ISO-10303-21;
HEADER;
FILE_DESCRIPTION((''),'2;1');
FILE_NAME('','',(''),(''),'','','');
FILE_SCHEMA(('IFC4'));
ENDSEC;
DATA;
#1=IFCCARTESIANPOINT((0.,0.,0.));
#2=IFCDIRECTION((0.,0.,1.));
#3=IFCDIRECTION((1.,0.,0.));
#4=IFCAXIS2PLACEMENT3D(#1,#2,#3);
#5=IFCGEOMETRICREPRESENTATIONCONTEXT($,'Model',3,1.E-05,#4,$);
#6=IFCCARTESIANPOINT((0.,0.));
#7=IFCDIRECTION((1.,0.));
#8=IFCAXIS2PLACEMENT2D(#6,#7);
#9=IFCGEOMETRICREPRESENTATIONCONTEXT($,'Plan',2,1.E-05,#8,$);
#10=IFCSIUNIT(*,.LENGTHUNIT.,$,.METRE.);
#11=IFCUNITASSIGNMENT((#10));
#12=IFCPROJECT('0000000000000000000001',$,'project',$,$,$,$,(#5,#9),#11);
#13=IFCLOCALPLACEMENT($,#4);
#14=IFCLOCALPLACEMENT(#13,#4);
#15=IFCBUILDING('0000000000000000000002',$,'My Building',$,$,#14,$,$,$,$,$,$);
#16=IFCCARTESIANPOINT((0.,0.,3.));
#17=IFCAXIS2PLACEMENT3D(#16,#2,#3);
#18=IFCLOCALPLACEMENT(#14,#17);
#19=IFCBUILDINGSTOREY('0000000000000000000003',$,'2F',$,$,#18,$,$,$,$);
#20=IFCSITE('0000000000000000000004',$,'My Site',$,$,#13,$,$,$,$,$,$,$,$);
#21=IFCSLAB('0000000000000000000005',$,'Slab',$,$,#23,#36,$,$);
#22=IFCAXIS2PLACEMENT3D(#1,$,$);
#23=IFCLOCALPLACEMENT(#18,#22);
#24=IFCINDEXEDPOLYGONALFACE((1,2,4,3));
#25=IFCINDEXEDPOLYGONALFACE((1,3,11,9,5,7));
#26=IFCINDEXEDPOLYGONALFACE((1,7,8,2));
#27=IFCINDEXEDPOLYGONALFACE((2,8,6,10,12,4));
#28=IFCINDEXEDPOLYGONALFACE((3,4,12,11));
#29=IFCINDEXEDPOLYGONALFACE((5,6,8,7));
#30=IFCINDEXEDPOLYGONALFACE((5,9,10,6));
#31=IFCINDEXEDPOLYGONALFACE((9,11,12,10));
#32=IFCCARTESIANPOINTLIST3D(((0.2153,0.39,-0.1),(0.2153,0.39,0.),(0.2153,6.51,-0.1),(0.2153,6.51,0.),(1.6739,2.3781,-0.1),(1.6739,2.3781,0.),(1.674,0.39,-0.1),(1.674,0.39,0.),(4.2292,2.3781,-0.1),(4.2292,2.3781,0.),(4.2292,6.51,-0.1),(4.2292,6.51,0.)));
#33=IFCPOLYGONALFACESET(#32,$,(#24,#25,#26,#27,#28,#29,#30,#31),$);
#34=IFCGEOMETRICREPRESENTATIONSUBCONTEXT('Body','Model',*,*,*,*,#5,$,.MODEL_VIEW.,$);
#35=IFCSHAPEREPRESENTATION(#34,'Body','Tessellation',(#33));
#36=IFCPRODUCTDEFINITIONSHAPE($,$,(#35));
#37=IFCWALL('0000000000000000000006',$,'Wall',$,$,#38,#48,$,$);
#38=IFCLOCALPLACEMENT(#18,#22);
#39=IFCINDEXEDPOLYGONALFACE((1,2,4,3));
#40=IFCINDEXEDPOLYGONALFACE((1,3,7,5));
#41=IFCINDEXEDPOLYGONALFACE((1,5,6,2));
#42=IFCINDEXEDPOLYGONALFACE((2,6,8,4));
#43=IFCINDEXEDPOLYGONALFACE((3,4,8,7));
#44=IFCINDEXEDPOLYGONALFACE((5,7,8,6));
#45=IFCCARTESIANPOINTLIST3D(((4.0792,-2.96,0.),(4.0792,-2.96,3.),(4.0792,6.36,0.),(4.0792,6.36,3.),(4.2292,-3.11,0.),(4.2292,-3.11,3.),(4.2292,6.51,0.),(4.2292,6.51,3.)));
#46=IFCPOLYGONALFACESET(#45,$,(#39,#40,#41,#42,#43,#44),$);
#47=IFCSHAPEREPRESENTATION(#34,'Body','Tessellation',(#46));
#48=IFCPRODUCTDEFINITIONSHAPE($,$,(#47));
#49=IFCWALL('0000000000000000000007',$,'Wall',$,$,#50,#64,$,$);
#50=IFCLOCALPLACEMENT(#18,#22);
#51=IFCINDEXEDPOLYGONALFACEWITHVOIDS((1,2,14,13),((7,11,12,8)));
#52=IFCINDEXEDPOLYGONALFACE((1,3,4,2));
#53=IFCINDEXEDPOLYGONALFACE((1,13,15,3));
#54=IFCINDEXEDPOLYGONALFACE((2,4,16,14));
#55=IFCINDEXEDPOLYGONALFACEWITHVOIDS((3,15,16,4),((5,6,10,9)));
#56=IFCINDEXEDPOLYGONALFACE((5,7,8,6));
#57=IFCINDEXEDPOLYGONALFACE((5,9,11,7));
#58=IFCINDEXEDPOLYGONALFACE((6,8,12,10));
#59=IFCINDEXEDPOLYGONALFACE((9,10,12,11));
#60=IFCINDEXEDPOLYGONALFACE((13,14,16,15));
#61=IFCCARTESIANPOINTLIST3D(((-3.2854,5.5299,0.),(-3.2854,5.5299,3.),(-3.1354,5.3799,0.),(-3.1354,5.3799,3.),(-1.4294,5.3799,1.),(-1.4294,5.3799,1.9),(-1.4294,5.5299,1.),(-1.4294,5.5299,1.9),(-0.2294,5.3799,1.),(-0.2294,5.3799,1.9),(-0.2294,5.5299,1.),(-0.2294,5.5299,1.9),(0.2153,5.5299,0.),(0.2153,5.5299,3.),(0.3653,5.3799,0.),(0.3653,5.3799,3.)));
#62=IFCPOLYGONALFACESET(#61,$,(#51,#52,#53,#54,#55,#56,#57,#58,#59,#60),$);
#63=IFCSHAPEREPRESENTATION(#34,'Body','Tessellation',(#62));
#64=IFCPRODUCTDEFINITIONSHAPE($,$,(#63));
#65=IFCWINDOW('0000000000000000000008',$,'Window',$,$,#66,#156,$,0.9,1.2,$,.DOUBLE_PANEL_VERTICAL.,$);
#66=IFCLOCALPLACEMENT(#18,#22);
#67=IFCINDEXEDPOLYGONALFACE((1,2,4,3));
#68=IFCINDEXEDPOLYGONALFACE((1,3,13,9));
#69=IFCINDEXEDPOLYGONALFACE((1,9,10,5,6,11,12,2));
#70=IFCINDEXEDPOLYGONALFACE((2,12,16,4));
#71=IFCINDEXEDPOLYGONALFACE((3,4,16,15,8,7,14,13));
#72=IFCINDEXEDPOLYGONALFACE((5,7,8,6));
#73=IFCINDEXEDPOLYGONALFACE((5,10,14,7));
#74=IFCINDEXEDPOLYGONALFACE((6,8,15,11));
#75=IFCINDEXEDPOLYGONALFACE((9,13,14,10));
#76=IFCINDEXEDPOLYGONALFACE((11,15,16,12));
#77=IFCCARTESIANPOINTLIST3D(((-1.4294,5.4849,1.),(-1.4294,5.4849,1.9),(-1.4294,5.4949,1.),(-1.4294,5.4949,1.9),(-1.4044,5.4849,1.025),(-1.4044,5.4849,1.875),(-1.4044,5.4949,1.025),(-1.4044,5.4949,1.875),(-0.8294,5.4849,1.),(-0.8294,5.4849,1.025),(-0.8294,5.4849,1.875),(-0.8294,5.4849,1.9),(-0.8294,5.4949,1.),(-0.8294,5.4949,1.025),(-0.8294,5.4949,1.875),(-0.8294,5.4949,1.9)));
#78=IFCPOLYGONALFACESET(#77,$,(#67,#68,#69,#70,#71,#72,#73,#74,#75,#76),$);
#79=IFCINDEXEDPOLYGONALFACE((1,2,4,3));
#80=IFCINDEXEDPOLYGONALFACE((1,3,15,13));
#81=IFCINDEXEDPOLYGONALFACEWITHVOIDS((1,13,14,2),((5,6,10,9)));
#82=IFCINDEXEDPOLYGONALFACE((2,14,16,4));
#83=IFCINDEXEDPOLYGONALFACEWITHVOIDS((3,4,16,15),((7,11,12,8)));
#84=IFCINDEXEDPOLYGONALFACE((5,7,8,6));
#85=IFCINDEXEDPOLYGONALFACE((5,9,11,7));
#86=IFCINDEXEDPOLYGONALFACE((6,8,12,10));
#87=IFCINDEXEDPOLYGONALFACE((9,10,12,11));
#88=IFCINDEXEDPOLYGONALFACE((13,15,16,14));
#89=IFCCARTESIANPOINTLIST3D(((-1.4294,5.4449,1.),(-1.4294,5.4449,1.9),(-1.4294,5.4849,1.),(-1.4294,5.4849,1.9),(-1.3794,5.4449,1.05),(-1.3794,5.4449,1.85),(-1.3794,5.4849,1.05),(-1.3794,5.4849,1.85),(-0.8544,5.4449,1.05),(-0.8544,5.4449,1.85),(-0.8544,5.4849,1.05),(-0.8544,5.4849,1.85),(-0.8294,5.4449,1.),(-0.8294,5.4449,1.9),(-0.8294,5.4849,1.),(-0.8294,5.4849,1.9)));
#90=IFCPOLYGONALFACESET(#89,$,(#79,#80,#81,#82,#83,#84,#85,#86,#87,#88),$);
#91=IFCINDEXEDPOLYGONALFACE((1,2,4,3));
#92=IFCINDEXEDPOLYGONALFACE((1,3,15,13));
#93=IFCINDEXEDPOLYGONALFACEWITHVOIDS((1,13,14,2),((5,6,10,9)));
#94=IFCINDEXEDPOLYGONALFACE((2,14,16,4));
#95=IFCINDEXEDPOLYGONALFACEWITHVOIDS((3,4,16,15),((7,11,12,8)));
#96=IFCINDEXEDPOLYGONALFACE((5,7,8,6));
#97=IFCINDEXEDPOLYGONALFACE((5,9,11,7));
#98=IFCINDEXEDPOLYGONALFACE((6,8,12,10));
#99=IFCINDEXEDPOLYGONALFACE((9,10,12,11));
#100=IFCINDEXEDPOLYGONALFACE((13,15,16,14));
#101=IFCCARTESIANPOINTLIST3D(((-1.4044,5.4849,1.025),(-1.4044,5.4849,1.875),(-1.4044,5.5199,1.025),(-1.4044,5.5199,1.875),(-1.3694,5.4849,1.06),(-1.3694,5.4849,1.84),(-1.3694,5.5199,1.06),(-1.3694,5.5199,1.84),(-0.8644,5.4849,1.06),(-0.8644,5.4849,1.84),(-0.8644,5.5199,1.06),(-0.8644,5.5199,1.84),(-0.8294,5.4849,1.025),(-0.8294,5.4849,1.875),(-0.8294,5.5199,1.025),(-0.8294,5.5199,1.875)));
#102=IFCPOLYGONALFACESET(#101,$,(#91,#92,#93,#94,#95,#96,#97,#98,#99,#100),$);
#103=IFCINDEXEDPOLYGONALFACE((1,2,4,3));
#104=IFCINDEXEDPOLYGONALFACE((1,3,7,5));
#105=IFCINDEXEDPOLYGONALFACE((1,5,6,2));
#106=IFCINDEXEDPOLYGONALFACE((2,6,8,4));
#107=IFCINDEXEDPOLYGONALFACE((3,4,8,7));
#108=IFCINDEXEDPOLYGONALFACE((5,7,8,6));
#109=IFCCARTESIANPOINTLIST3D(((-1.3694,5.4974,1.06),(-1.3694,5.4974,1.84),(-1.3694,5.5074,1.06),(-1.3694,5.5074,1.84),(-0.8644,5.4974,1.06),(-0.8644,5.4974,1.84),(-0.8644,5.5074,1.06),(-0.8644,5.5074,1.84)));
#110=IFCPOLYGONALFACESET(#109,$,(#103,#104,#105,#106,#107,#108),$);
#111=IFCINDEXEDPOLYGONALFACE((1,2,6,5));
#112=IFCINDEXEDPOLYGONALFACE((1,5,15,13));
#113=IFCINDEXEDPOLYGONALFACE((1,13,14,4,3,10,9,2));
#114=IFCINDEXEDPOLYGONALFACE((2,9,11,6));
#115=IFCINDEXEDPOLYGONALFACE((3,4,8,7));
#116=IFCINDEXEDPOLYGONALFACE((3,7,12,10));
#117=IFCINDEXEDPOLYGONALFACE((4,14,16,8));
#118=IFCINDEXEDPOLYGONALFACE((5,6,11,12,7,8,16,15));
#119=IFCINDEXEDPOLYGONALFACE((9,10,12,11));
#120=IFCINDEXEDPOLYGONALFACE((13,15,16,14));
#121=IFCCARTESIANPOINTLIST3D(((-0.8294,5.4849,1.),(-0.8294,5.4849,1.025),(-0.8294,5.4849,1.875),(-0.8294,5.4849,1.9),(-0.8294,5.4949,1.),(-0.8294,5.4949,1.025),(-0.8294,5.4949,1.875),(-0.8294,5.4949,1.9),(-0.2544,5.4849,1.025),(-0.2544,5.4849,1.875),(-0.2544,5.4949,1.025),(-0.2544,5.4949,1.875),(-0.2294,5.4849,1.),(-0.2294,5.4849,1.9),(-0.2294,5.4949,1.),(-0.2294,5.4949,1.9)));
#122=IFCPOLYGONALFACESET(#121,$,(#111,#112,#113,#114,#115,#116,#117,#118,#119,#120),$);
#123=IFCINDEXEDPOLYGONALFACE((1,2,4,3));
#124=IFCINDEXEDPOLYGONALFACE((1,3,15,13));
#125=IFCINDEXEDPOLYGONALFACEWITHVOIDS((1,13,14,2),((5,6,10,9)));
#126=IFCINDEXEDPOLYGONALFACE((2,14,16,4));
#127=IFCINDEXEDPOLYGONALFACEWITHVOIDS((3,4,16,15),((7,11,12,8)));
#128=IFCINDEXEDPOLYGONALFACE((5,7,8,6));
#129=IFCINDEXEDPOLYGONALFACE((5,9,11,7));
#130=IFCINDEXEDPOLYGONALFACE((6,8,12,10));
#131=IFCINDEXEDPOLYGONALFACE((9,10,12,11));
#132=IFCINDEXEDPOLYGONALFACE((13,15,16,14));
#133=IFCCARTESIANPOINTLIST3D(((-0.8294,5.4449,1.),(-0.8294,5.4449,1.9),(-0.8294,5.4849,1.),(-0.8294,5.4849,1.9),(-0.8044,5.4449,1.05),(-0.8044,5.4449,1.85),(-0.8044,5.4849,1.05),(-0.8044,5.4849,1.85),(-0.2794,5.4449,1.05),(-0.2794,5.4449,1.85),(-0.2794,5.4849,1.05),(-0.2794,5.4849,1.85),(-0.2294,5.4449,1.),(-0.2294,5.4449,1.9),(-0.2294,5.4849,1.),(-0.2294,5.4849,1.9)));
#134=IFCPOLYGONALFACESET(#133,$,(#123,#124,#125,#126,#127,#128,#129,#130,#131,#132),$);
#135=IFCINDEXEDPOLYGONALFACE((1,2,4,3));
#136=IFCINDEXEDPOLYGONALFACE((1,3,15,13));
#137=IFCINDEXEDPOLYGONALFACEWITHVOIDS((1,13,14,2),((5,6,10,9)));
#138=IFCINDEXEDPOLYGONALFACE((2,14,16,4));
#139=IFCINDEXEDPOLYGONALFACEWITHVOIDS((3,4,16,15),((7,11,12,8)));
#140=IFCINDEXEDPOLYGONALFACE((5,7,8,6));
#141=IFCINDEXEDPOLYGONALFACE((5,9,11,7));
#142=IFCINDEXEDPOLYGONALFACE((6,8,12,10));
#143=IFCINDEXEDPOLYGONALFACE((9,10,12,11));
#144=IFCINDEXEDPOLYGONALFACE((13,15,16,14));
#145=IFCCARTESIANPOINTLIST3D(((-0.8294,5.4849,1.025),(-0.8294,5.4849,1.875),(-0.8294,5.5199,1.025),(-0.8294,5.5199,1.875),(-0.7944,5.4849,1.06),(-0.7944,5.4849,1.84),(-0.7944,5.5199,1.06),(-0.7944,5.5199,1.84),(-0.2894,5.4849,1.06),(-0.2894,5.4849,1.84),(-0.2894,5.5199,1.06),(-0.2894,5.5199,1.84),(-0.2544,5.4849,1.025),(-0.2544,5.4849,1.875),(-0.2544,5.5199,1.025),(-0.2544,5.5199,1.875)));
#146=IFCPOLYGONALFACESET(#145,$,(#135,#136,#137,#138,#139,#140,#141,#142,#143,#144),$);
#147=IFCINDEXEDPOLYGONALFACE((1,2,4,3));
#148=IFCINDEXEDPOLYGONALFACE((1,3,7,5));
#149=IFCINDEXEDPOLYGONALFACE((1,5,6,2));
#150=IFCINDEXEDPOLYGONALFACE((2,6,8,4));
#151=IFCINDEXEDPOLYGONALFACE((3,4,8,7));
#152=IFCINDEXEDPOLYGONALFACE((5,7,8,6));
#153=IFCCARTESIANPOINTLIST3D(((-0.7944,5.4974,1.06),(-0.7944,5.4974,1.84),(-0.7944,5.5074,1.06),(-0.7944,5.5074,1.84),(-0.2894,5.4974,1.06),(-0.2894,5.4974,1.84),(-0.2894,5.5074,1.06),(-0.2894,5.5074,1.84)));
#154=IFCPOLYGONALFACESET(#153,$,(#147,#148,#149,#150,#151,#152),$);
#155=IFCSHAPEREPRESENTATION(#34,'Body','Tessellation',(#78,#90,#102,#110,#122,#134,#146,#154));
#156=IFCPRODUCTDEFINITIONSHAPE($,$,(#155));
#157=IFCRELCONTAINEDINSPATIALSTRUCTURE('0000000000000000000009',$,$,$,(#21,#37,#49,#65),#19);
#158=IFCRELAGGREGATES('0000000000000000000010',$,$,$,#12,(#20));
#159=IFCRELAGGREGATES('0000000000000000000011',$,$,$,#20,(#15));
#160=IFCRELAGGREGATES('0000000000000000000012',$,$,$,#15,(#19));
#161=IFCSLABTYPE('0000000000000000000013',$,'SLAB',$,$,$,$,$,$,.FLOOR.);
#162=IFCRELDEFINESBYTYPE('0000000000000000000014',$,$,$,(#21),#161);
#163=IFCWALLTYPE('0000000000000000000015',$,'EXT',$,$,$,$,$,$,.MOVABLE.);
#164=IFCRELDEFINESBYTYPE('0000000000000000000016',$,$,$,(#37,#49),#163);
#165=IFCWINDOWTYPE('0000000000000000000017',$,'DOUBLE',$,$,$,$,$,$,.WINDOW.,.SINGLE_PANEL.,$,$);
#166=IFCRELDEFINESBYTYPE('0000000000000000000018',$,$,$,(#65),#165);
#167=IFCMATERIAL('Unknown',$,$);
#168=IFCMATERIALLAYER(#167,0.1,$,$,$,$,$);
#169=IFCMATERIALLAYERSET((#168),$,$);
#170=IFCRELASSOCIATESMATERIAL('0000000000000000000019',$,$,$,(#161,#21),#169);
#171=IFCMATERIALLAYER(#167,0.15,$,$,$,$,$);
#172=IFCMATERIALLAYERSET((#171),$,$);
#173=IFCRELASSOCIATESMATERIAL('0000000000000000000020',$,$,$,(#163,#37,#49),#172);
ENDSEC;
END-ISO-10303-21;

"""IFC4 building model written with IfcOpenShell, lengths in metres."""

from ifc_helpers import new_model, entity, si_unit, frame, origin_with_axes, origin_2d_with_axis, place, context, subcontext, project, spatial, line, indexed_curve, outline, extrude, shape, source, transform, mapped, material, layer, layer_set, layer_usage, type_object, type_shapes, element, fill, save


model = new_model("IFC4")

# Units and contexts
model_context = context("Model", 3, precision=1e-05, world=origin_with_axes())
plan_context = context("Plan", 2, precision=1e-05, world=origin_2d_with_axis())
body_context_1 = subcontext(model_context, "Body", "Model", "MODEL_VIEW")
body_context_2 = subcontext(plan_context, "Body", "Plan", "PLAN_VIEW")
ifc_project = project(units=[si_unit("LENGTHUNIT", "METRE")], contexts=[model_context, plan_context])

# Site, building, storey
site_placement = place(None, origin_with_axes())
site = spatial("IfcSite", under=ifc_project, at=site_placement, Name="My Site")
building_placement = place(site_placement, origin_with_axes())
building = spatial("IfcBuilding", under=site, at=building_placement, Name="My Building")
storey_placement = place(building_placement, frame((0.0, 0.0, 3.0), z_axis=(0.0, 0.0, 1.0), x_axis=(1.0, 0.0, 0.0)))
storey = spatial("IfcBuildingStorey", under=building, at=storey_placement, Name="2F")

# Slab
ifc_material = material(Name="Unknown")
ifc_layer_1 = layer(ifc_material, 0.1)
ifc_layer_set_1 = layer_set([ifc_layer_1])
ifc_layer_usage_1 = layer_usage(ifc_layer_set_1, "AXIS3", "POSITIVE", -0.1)
slab_type = type_object("IfcSlabType", Name="SLAB", PredefinedType="FLOOR", material=ifc_layer_set_1)
slab_placement = place(storey_placement, frame((1.6739, 2.3781, 0.0), z_axis=(0.0, 0.0, 1.0), x_axis=(1.0, 0.0, 0.0)))
element("IfcSlab", 1, at=slab_placement, inside=storey, type_object=slab_type, material=ifc_layer_usage_1, Name="Slab", context=body_context_1, shape_type="SweptSolid", body=[
    extrude(outline(indexed_curve([(0.0, 0.0), (2.5552, 0.0), (2.5552, 4.1319), (-1.4586, 4.1319), (-1.4586, -1.9882), (0.0, -1.9882), (0.0, 0.0)])), frame((0.0, 0.0, -0.1), z_axis=(0.0, 0.0, 1.0), x_axis=(1.0, 0.0, 0.0)), (0.0, 0.0, 1.0), 0.1),
])

# Wall
ifc_layer_2 = layer(ifc_material, 0.15)
ifc_layer_set_2 = layer_set([ifc_layer_2])
ifc_layer_usage_2 = layer_usage(ifc_layer_set_2, "AXIS2", "POSITIVE", -0.15)
wall_type_1 = type_object("IfcWallType", Name="EXT", PredefinedType="MOVABLE", material=ifc_layer_set_2)
wall_1_placement = place(storey_placement, frame((4.2292, 6.51, 0.0), z_axis=(0.0, 0.0, 1.0), x_axis=(0.0, -1.0, 0.0)))
element("IfcWall", 2, at=wall_1_placement, inside=storey, type_object=wall_type_1, material=ifc_layer_usage_2, Name="Wall", context=body_context_1, shape_type="SweptSolid", body=[
    extrude(outline(indexed_curve([(0.15, -0.15), (0.0, 0.0), (9.62, 0.0), (9.47, -0.15)], segments=[line(1, 2, 3, 4, 1)])), origin_with_axes(), (0.0, 0.0, 1.0), 3.0),
])

# Wall, opening, window
ifc_layer_usage_3 = layer_usage(ifc_layer_set_2, "AXIS2", "POSITIVE", -0.15)
wall_2_placement = place(storey_placement, frame((-3.2854, 5.5299, 0.0), z_axis=(0.0, 0.0, 1.0), x_axis=(1.0, 0.0, 0.0)))
wall_2 = element("IfcWall", 3, at=wall_2_placement, inside=storey, type_object=wall_type_1, material=ifc_layer_usage_3, Name="Wall", context=body_context_1, shape_type="SweptSolid", body=[
    extrude(outline(indexed_curve([(0.15, -0.15), (0.0, 0.0), (3.5007, 0.0), (3.6507, -0.15)], segments=[line(1, 2, 3, 4, 1)])), origin_with_axes(), (0.0, 0.0, 1.0), 3.0),
])
placement_1 = place(storey_placement, frame((-1.4294, 5.3949, 1.0), z_axis=(0.0, 0.0, 1.0), x_axis=(1.0, 0.0, 0.0)))
opening_1 = element("IfcOpeningElement", 4, at=placement_1, cuts=wall_2, PredefinedType="OPENING", context=body_context_1, shape_type="SweptSolid", body=[
    extrude(outline(indexed_curve([(0.0, 0.0), (1.2, 0.0), (1.2, 0.9), (0.0, 0.9)], segments=[line(1, 2, 3, 4, 1)])), frame((0.0, -0.6, 0.0), z_axis=(0.0, -1.0, 0.0), x_axis=(1.0, 0.0, 0.0)), (0.0, 0.0, -1.0), 1.2),
])
window_type_1 = type_object("IfcWindowType", Name="DOUBLE", PartitioningType="SINGLE_PANEL", PredefinedType="WINDOW")
shared_shape_1 = source(origin_with_axes(), body_context_1, "Body", "SweptSolid", [
    extrude(outline(indexed_curve([(0.6, 0.0), (0.0, 0.0), (0.0, 0.9), (0.6, 0.9), (0.6, 0.875), (0.025, 0.875), (0.025, 0.025), (0.6, 0.025)], segments=[line(1, 2, 3, 4, 5, 6, 7, 8, 1)])), frame((0.0, 0.09, 0.0), z_axis=(0.0, -1.0, 0.0), x_axis=(1.0, 0.0, 0.0)), (0.0, 0.0, -1.0), 0.01),
    extrude(outline(indexed_curve([(0.0, 0.0), (0.6, 0.0), (0.6, 0.9), (0.0, 0.9)], segments=[line(1, 2, 3, 4, 1)]), holes=[indexed_curve([(0.05, 0.05), (0.575, 0.05), (0.575, 0.85), (0.05, 0.85)], segments=[line(1, 2, 3, 4, 1)])]), frame((0.0, 0.05, 0.0), z_axis=(0.0, -1.0, 0.0), x_axis=(1.0, 0.0, 0.0)), (0.0, 0.0, -1.0), 0.04),
    extrude(outline(indexed_curve([(0.0, 0.0), (0.575, 0.0), (0.575, 0.85), (0.0, 0.85)], segments=[line(1, 2, 3, 4, 1)]), holes=[indexed_curve([(0.035, 0.035), (0.54, 0.035), (0.54, 0.815), (0.035, 0.815)], segments=[line(1, 2, 3, 4, 1)])]), frame((0.025, 0.09, 0.025), z_axis=(0.0, -1.0, 0.0), x_axis=(1.0, 0.0, 0.0)), (0.0, 0.0, -1.0), 0.035),
    extrude(outline(indexed_curve([(0.035, 0.035), (0.54, 0.035), (0.54, 0.815), (0.035, 0.815)], segments=[line(1, 2, 3, 4, 1)])), frame((0.025, 0.1025, 0.025), z_axis=(0.0, -1.0, 0.0), x_axis=(1.0, 0.0, 0.0)), (0.0, 0.0, -1.0), 0.01),
    extrude(outline(indexed_curve([(0.0, 0.9), (0.6, 0.9), (0.6, 0.0), (0.0, 0.0), (0.0, 0.025), (0.575, 0.025), (0.575, 0.875), (0.0, 0.875)], segments=[line(1, 2, 3, 4, 5, 6, 7, 8, 1)])), frame((0.6, 0.09, 0.0), z_axis=(0.0, -1.0, 0.0), x_axis=(1.0, 0.0, 0.0)), (0.0, 0.0, -1.0), 0.01),
    extrude(outline(indexed_curve([(0.0, 0.0), (0.6, 0.0), (0.6, 0.9), (0.0, 0.9)], segments=[line(1, 2, 3, 4, 1)]), holes=[indexed_curve([(0.025, 0.05), (0.55, 0.05), (0.55, 0.85), (0.025, 0.85)], segments=[line(1, 2, 3, 4, 1)])]), frame((0.6, 0.05, 0.0), z_axis=(0.0, -1.0, 0.0), x_axis=(1.0, 0.0, 0.0)), (0.0, 0.0, -1.0), 0.04),
    extrude(outline(indexed_curve([(0.0, 0.0), (0.575, 0.0), (0.575, 0.85), (0.0, 0.85)], segments=[line(1, 2, 3, 4, 1)]), holes=[indexed_curve([(0.035, 0.035), (0.54, 0.035), (0.54, 0.815), (0.035, 0.815)], segments=[line(1, 2, 3, 4, 1)])]), frame((0.6, 0.09, 0.025), z_axis=(0.0, -1.0, 0.0), x_axis=(1.0, 0.0, 0.0)), (0.0, 0.0, -1.0), 0.035),
    extrude(outline(indexed_curve([(0.035, 0.815), (0.54, 0.815), (0.54, 0.035), (0.035, 0.035), (0.035, 0.815)])), frame((0.6, 0.1025, 0.025), z_axis=(0.0, -1.0, 0.0), x_axis=(1.0, 0.0, 0.0)), (0.0, 0.0, -1.0), 0.01),
])
shared_shape_2 = source(origin_with_axes(), body_context_2, "Body", "Curve2D", [
    entity("IfcIndexedPolyCurve", entity("IfcCartesianPointList2D", [[0.05, 0.05], [0.575, 0.05]])),
    entity("IfcIndexedPolyCurve", entity("IfcCartesianPointList2D", [[0.0, 0.1], [0.025, 0.1], [0.025, 0.09], [0.05, 0.09], [0.05, 0.05], [0.0, 0.05]]), [entity("IfcLineIndex", [1, 2, 3, 4, 5, 6, 1])]),
    entity("IfcIndexedPolyCurve", entity("IfcCartesianPointList2D", [[0.6, 0.1], [0.6, 0.1], [0.6, 0.09], [0.575, 0.09], [0.575, 0.05], [0.6, 0.05]])),
    entity("IfcIndexedPolyCurve", entity("IfcCartesianPointList2D", [[0.025, 0.09], [0.06, 0.09], [0.06, 0.125], [0.025, 0.125]]), [entity("IfcLineIndex", [1, 2, 3, 4, 1])]),
    entity("IfcIndexedPolyCurve", entity("IfcCartesianPointList2D", [[0.6, 0.09], [0.565, 0.09], [0.565, 0.125], [0.6, 0.125]]), [entity("IfcLineIndex", [1, 2, 3, 4, 1])]),
    entity("IfcIndexedPolyCurve", entity("IfcCartesianPointList2D", [[0.06, 0.09], [0.565, 0.09]])),
    entity("IfcIndexedPolyCurve", entity("IfcCartesianPointList2D", [[0.06, 0.125], [0.565, 0.125]])),
    entity("IfcIndexedPolyCurve", entity("IfcCartesianPointList2D", [[0.06, 0.1075], [0.565, 0.1075]])),
    entity("IfcIndexedPolyCurve", entity("IfcCartesianPointList2D", [[0.625, 0.05], [1.15, 0.05]])),
    entity("IfcIndexedPolyCurve", entity("IfcCartesianPointList2D", [[0.6, 0.1], [0.6, 0.1], [0.6, 0.09], [0.625, 0.09], [0.625, 0.05], [0.6, 0.05]])),
    entity("IfcIndexedPolyCurve", entity("IfcCartesianPointList2D", [[1.2, 0.1], [1.175, 0.1], [1.175, 0.09], [1.15, 0.09], [1.15, 0.05], [1.2, 0.05]]), [entity("IfcLineIndex", [1, 2, 3, 4, 5, 6, 1])]),
    entity("IfcIndexedPolyCurve", entity("IfcCartesianPointList2D", [[0.6, 0.09], [0.635, 0.09], [0.635, 0.125], [0.6, 0.125]]), [entity("IfcLineIndex", [1, 2, 3, 4, 1])]),
    entity("IfcIndexedPolyCurve", entity("IfcCartesianPointList2D", [[1.175, 0.09], [1.14, 0.09], [1.14, 0.125], [1.175, 0.125]]), [entity("IfcLineIndex", [1, 2, 3, 4, 1])]),
    entity("IfcIndexedPolyCurve", entity("IfcCartesianPointList2D", [[0.635, 0.09], [1.14, 0.09]])),
    entity("IfcIndexedPolyCurve", entity("IfcCartesianPointList2D", [[0.635, 0.125], [1.14, 0.125]])),
    entity("IfcIndexedPolyCurve", entity("IfcCartesianPointList2D", [[0.635, 0.1075], [1.14, 0.1075]])),
])
type_shapes(window_type_1, [shared_shape_1, shared_shape_2])
window_1 = element("IfcWindow", 5, at=placement_1, inside=storey, type_object=window_type_1, Name="Window", OverallHeight=0.9, OverallWidth=1.2, PartitioningType="DOUBLE_PANEL_VERTICAL", shapes=[
    shape(body_context_1, "Body", "MappedRepresentation", [mapped(shared_shape_1, transform((0.0, 0.0, 0.0), x_axis=(1.0, 0.0, 0.0), y_axis=(0.0, 1.0, 0.0), z_axis=(0.0, 0.0, 1.0), scale=1.0))]),
    shape(body_context_2, "Body", "MappedRepresentation", [mapped(shared_shape_2, transform((0.0, 0.0, 0.0), x_axis=(1.0, 0.0, 0.0), y_axis=(0.0, 1.0, 0.0), z_axis=(0.0, 0.0, 1.0), scale=1.0))]),
])
fill(opening_1, window_1)

save(model, "model.ifc")
